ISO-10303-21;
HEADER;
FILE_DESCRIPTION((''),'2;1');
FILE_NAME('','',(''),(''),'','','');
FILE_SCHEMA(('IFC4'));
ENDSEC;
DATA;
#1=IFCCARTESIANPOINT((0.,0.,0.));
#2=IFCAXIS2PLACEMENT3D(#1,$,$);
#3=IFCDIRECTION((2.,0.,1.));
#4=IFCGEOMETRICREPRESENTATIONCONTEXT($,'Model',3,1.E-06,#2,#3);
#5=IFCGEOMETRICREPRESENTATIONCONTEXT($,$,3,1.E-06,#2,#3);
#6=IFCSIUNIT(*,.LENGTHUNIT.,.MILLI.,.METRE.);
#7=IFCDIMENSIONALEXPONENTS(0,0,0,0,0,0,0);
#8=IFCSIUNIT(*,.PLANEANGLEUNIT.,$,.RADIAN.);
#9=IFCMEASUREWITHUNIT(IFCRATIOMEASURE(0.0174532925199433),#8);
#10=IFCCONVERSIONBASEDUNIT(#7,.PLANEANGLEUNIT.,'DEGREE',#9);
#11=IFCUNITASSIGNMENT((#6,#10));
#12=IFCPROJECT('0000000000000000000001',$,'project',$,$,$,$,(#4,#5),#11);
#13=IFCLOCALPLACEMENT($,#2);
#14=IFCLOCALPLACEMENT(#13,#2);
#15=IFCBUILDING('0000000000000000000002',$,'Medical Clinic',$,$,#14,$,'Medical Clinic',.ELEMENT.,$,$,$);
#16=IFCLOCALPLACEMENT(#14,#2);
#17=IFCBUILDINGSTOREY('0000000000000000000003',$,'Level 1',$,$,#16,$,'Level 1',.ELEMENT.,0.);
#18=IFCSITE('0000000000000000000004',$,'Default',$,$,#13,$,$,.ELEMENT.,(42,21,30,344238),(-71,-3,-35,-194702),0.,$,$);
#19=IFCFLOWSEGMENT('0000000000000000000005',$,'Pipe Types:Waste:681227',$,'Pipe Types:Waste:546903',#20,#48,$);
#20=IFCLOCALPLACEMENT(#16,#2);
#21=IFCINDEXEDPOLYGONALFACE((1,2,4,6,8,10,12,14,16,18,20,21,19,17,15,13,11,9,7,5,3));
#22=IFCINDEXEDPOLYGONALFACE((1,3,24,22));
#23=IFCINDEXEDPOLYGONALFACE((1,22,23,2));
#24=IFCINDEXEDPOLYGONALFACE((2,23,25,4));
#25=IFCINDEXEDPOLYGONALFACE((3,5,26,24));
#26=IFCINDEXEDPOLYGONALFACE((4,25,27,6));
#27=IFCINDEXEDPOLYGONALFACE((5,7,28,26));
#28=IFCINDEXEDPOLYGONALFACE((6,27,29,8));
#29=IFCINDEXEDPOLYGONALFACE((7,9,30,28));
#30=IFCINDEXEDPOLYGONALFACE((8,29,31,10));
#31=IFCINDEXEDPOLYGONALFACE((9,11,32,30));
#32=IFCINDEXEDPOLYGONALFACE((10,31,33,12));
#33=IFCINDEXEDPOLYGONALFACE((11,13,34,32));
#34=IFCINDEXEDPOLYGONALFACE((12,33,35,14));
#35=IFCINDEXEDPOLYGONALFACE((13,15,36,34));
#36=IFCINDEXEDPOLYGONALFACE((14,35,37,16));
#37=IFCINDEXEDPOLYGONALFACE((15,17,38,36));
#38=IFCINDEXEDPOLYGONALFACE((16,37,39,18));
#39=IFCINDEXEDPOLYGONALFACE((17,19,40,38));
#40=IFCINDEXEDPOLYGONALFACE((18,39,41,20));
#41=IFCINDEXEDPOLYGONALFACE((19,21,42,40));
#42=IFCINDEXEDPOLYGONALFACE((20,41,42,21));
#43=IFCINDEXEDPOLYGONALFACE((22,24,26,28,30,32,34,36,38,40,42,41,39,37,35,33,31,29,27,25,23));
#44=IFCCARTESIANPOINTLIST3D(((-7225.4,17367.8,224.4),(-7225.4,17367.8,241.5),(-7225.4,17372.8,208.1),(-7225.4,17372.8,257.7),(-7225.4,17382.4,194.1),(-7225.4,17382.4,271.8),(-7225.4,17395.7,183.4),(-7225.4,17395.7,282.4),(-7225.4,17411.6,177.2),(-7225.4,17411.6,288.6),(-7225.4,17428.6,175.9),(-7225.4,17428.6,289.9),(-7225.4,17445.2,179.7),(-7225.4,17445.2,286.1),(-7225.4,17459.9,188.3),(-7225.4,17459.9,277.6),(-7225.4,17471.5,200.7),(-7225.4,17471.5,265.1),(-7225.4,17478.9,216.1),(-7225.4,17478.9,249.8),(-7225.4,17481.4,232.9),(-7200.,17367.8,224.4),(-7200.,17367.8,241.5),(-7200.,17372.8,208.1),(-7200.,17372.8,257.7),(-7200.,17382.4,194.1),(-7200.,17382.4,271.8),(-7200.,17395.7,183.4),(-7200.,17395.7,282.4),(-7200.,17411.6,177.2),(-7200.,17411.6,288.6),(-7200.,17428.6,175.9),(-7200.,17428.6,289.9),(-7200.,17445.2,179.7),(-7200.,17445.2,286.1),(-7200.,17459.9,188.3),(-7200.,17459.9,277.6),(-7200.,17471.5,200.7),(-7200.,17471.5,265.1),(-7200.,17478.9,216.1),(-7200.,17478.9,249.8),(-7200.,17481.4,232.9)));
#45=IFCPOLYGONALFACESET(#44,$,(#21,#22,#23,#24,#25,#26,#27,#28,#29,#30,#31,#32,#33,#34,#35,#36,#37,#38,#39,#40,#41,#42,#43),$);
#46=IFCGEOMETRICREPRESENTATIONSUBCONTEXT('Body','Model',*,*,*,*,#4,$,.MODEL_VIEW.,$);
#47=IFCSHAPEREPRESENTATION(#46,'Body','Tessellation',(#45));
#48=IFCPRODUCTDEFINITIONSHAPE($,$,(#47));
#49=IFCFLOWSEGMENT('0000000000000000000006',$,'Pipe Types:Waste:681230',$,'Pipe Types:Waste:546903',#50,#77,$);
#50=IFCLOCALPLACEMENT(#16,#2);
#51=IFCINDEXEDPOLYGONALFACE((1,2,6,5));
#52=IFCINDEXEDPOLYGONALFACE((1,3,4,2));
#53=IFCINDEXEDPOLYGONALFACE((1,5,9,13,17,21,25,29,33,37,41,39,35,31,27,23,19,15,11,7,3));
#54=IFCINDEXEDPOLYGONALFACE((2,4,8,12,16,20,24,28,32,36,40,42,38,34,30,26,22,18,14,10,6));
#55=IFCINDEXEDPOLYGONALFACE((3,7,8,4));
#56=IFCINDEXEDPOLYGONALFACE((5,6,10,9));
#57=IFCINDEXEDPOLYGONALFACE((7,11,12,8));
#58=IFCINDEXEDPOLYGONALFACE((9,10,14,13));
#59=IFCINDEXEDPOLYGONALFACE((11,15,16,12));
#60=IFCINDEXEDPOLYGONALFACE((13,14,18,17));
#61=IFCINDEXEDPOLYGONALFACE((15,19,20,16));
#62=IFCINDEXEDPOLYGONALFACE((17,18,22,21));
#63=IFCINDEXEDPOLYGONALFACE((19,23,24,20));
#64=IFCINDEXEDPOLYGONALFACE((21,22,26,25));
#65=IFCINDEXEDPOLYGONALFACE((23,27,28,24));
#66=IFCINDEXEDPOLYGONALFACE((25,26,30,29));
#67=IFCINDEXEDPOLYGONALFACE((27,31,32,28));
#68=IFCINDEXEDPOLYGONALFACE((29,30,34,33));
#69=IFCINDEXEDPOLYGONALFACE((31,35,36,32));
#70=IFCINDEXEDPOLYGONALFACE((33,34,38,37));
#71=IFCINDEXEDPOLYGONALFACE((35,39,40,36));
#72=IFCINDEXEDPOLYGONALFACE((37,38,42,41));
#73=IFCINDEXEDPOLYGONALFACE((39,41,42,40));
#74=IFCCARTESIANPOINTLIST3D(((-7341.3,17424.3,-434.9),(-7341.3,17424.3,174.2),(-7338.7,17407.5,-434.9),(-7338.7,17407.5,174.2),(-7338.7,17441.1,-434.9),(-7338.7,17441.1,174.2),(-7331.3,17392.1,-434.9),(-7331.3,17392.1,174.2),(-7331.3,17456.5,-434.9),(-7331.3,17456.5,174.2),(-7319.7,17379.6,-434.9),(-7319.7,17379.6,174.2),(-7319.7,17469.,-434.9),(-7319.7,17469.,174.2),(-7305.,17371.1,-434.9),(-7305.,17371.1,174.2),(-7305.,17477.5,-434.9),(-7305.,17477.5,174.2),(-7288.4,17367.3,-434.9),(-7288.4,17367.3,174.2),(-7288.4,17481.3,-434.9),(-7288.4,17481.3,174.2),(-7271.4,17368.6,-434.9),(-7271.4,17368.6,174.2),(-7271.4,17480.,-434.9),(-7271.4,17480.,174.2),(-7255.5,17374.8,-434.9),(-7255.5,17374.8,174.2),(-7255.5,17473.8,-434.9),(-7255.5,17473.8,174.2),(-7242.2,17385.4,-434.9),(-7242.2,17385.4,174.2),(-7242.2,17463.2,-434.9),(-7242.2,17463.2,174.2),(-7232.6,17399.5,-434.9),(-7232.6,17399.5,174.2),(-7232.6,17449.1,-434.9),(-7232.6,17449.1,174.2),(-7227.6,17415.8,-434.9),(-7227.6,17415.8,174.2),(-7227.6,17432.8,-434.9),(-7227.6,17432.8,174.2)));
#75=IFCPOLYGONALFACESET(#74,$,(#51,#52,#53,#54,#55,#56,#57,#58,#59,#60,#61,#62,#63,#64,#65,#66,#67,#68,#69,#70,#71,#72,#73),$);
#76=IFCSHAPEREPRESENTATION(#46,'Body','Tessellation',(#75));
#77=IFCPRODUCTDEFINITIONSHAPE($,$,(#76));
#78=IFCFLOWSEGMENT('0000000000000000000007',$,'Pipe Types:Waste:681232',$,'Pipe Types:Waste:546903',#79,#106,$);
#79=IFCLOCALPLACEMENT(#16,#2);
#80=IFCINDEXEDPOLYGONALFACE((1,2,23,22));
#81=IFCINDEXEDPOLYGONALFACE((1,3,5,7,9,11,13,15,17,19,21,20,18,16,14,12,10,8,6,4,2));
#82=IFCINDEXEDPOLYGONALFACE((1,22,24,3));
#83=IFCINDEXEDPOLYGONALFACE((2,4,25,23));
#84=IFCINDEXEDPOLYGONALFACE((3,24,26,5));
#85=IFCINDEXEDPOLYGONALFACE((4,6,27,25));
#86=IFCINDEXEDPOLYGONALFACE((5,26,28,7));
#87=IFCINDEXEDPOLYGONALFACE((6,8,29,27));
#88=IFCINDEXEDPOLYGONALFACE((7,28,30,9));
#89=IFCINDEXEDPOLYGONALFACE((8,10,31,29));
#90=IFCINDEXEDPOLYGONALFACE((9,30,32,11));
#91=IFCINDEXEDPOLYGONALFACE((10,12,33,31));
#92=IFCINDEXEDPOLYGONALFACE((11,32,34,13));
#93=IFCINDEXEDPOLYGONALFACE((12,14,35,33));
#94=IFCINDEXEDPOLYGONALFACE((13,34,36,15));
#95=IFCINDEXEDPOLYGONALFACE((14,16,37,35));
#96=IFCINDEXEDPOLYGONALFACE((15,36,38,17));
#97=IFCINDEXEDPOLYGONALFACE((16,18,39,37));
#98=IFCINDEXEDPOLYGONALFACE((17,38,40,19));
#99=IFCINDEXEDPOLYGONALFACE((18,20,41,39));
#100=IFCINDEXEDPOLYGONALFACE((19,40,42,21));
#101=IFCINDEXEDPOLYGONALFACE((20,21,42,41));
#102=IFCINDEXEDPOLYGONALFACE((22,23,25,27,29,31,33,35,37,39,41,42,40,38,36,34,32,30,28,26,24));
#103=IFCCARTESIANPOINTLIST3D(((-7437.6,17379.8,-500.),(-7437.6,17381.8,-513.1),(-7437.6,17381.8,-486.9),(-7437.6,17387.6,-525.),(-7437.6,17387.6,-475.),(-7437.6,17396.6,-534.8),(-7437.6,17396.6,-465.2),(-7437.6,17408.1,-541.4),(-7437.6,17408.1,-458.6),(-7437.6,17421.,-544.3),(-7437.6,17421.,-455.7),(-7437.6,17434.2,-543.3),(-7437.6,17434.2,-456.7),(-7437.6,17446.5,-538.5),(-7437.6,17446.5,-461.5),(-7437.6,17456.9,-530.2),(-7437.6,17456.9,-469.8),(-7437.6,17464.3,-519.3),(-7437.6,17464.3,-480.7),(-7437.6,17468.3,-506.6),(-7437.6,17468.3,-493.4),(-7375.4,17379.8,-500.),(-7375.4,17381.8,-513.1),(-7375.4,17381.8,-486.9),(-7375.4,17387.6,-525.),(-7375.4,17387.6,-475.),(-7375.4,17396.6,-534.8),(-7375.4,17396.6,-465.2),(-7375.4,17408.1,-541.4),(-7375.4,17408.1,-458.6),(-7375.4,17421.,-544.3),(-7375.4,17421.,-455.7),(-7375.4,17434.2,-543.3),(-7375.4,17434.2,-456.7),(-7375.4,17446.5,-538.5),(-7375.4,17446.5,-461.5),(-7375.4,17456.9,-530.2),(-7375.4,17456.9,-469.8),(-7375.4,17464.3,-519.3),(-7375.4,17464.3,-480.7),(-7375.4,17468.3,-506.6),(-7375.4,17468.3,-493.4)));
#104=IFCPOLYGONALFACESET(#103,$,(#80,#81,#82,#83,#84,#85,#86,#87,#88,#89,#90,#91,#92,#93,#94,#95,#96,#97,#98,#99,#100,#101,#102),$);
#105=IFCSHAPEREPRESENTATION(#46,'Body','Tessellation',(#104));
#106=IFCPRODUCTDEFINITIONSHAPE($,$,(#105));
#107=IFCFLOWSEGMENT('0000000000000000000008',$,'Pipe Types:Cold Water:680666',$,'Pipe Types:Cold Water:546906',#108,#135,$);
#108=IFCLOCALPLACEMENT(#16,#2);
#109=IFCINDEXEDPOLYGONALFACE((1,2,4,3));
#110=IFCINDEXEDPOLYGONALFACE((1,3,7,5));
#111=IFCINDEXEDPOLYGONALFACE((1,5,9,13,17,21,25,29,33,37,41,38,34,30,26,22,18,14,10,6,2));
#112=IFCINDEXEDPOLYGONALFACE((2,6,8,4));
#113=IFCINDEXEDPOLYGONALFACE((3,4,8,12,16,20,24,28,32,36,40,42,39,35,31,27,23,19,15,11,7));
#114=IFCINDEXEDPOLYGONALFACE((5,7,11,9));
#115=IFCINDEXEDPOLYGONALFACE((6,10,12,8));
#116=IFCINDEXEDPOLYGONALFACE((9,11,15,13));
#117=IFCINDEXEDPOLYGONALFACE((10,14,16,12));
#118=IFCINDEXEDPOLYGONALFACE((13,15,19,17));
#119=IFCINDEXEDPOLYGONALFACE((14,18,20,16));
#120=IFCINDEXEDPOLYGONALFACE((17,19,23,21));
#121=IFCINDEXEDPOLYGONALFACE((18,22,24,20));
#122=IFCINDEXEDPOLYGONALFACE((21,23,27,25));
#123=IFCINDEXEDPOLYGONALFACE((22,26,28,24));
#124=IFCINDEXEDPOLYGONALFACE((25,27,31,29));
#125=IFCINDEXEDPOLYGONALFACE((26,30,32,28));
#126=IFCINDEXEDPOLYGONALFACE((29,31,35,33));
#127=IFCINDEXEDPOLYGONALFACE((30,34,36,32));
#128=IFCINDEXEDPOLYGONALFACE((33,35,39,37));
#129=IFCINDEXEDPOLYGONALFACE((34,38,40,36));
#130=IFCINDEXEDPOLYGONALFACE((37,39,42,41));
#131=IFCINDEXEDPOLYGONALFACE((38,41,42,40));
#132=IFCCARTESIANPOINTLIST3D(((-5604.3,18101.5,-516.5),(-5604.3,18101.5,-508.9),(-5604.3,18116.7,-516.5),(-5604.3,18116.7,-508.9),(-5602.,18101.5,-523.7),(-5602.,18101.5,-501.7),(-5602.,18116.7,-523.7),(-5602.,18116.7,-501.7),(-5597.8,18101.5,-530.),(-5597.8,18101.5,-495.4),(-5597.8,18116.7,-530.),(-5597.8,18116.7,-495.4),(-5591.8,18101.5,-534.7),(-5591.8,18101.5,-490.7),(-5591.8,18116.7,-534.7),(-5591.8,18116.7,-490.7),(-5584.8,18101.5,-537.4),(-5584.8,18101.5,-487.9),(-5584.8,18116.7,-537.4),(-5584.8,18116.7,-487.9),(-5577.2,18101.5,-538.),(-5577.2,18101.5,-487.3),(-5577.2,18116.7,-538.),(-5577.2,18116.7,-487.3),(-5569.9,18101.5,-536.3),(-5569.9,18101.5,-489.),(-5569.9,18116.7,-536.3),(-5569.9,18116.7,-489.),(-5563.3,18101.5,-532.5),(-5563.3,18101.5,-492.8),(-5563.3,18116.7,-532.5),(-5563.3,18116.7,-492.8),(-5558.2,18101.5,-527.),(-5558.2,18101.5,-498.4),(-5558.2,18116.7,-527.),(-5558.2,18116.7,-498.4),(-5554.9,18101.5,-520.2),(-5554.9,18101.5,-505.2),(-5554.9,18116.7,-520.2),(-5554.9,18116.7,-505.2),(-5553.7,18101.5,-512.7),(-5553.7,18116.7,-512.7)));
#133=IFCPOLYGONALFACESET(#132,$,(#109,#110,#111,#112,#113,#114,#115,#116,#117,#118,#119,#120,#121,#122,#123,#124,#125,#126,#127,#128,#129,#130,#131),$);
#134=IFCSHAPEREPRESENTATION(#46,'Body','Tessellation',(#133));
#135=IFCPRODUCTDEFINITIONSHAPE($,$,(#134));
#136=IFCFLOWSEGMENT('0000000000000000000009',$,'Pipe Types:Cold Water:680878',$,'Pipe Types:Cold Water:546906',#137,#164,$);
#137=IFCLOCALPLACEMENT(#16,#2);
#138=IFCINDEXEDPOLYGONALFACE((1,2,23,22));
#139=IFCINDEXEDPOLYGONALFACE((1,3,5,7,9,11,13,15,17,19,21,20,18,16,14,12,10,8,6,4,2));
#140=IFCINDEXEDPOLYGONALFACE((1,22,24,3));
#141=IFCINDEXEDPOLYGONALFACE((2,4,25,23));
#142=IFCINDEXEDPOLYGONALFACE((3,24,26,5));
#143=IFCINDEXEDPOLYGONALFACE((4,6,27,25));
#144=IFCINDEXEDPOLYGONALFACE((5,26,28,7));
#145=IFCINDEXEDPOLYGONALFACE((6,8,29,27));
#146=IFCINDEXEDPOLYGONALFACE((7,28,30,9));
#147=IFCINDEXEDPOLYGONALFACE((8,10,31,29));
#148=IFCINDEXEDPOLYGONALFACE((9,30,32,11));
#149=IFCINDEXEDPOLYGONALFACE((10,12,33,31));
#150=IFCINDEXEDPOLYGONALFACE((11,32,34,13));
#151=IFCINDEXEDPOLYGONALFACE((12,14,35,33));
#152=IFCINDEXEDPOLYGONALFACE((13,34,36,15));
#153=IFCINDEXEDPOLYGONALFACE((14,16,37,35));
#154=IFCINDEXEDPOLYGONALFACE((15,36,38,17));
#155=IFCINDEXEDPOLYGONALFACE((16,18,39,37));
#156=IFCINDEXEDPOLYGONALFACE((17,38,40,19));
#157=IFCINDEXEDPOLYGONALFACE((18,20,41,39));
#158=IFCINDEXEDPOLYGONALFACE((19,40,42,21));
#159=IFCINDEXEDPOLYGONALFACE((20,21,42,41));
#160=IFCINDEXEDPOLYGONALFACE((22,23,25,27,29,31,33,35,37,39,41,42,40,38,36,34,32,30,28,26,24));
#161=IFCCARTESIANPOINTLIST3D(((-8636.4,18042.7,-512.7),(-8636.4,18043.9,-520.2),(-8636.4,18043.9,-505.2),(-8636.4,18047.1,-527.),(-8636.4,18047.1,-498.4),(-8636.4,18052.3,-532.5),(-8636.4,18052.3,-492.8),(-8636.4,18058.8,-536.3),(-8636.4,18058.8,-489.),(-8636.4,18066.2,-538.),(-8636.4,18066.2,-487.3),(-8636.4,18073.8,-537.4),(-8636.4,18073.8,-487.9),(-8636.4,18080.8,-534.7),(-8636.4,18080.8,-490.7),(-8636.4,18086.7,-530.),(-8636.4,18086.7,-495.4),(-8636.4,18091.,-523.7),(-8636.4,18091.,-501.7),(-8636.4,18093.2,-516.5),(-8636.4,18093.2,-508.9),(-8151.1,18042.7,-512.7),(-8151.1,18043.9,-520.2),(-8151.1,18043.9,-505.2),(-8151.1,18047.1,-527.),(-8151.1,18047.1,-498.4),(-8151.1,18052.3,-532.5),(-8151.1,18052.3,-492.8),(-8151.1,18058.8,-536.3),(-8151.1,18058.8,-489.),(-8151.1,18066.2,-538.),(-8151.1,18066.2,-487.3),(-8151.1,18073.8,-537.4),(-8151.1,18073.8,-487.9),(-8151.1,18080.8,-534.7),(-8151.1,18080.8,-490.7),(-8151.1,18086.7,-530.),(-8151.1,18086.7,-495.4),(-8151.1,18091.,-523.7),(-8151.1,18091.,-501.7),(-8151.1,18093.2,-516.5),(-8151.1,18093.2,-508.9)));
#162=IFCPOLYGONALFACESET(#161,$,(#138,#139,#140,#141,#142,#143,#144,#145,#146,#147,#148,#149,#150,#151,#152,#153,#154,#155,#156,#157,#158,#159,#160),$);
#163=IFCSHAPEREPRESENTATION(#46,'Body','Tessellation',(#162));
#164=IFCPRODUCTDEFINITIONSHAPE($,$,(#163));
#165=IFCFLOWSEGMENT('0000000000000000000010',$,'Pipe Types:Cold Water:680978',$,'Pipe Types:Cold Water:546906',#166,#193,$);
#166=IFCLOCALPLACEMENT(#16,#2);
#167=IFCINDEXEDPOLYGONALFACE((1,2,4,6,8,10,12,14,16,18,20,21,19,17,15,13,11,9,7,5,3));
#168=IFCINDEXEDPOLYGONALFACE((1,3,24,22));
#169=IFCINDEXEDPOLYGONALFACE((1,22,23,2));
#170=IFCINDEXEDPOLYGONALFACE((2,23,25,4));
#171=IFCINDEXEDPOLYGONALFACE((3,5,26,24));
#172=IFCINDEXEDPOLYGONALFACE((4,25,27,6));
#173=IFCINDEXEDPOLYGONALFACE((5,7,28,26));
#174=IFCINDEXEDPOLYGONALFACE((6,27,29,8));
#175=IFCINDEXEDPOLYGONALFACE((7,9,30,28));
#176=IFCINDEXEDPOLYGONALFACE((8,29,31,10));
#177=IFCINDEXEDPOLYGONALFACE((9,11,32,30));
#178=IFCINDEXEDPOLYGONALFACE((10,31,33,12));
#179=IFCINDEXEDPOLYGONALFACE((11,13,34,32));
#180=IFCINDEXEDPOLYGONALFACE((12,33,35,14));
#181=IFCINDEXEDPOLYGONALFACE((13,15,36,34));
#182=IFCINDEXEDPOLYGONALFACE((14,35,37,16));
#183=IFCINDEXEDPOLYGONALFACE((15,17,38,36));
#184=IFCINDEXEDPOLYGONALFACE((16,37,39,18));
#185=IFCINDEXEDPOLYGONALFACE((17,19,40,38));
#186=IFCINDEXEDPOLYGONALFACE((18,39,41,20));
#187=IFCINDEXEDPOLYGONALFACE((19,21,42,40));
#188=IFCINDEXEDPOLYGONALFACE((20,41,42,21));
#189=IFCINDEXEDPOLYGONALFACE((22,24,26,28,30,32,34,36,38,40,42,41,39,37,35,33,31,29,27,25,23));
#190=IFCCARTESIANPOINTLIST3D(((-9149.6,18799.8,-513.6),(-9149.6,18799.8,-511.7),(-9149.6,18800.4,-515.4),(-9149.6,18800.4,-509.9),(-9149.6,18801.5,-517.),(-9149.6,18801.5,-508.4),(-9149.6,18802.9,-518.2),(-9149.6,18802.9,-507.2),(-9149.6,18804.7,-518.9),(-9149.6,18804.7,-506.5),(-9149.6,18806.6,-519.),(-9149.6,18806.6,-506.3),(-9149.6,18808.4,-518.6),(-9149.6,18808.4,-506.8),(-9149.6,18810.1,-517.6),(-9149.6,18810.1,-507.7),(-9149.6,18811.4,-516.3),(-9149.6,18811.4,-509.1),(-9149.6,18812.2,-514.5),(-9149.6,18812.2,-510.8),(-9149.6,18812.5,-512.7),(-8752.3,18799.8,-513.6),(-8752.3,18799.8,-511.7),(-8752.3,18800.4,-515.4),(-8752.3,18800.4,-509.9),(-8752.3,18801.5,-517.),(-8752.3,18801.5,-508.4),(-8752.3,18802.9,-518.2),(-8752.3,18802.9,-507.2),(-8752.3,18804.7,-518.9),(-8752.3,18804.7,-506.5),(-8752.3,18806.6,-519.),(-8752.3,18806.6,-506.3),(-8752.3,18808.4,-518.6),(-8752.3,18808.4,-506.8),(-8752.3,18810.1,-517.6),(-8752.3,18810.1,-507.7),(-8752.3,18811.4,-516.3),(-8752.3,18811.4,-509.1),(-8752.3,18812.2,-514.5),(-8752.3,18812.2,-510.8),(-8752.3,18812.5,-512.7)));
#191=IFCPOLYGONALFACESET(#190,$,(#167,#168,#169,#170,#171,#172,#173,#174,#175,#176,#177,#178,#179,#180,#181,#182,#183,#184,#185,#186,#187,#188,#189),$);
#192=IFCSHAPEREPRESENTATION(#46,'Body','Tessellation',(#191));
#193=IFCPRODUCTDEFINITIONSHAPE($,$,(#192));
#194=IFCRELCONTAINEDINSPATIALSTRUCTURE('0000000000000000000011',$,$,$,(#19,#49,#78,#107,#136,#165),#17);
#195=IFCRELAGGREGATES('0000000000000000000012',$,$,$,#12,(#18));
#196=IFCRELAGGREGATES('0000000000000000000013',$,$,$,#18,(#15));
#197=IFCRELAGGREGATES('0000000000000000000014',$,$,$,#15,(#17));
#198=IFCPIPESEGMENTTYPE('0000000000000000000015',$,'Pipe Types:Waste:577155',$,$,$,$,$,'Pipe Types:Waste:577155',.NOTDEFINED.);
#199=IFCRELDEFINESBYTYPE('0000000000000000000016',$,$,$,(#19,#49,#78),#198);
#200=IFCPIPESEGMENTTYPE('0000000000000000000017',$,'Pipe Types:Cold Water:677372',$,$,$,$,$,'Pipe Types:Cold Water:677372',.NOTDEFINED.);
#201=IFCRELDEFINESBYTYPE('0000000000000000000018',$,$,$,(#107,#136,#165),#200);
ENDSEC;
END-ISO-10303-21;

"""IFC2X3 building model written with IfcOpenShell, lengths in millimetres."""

from ifc_helpers import new_model, entity, si_unit, converted_unit, direction, frame, frame_2d, origin, origin_2d_with_axis, place, context, subcontext, project, spatial, circle, extrude, type_object, element, save


model = new_model("IFC2X3")

# Units and contexts
model_context = context("Model", 3, precision=1e-06, world=origin(), true_north=direction((2.0, 0.0, 1.0)))
context_of_model = context(None, 3, precision=1e-06, world=origin(), true_north=direction((2.0, 0.0, 1.0)))
body_context = subcontext(model_context, "Body", "Model", "MODEL_VIEW")
ifc_project = project(units=[si_unit("LENGTHUNIT", "METRE", prefix="MILLI"), converted_unit("PLANEANGLEUNIT", "DEGREE", entity("IfcRatioMeasure", 0.0174532925199433), si_unit("PLANEANGLEUNIT", "RADIAN"), dimensions=[0, 0, 0, 0, 0, 0, 0])], contexts=[model_context, context_of_model])

# Site, building, storey
site_placement = place(None, origin())
site = spatial("IfcSite", under=ifc_project, at=site_placement, Name="Default", CompositionType="ELEMENT", RefLatitude=(42, 21, 30, 344238), RefLongitude=(-71, -3, -35, -194702), RefElevation=0.0)
building_placement = place(site_placement, origin())
building = spatial("IfcBuilding", under=site, at=building_placement, Name="Medical Clinic", LongName="Medical Clinic", CompositionType="ELEMENT")
storey_placement = place(building_placement, origin())
storey = spatial("IfcBuildingStorey", under=building, at=storey_placement, Name="Level 1", LongName="Level 1", CompositionType="ELEMENT", Elevation=0.0)

# Flow segments
pipe_segment_type_1 = type_object("IfcPipeSegmentType", Name="Pipe Types:Waste:577155", ElementType="Pipe Types:Waste:577155", PredefinedType="NOTDEFINED")
flow_segment_1_placement = place(storey_placement, origin())
element("IfcFlowSegment", 1, at=flow_segment_1_placement, inside=storey, type_object=pipe_segment_type_1, Name="Pipe Types:Waste:681227", ObjectType="Pipe Types:Waste:546903", context=body_context, shape_type="SweptSolid", body=[
    extrude(circle(Radius=57.1, at=frame_2d((0.0, 0.0), x_axis=(1.0, 0.0))), frame((-7225.4, 17424.3, 232.9), z_axis=(1.0, 0.0, 0.0), x_axis=(0.0, 1.0, 0.0)), (0.0, 0.0, 1.0), 25.4),
])
flow_segment_2_placement = place(storey_placement, origin())
element("IfcFlowSegment", 2, at=flow_segment_2_placement, inside=storey, type_object=pipe_segment_type_1, Name="Pipe Types:Waste:681230", ObjectType="Pipe Types:Waste:546903", context=body_context, shape_type="SweptSolid", body=[
    extrude(circle(Radius=57.1, at=origin_2d_with_axis()), frame((-7284.1, 17424.3, -434.9), z_axis=(0.0, 0.0, 1.0), x_axis=(-1.0, 0.0, 0.0)), (0.0, 0.0, 1.0), 609.1),
])
flow_segment_3_placement = place(storey_placement, origin())
element("IfcFlowSegment", 3, at=flow_segment_3_placement, inside=storey, type_object=pipe_segment_type_1, Name="Pipe Types:Waste:681232", ObjectType="Pipe Types:Waste:546903", context=body_context, shape_type="SweptSolid", body=[
    extrude(circle(Radius=44.5, at=frame_2d((0.0, 0.0), x_axis=(1.0, 0.0))), frame((-7437.6, 17424.3, -500.0), z_axis=(1.0, 0.0, 0.0), x_axis=(0.0, -1.0, 0.0)), (0.0, 0.0, 1.0), 62.2),
])
pipe_segment_type_2 = type_object("IfcPipeSegmentType", Name="Pipe Types:Cold Water:677372", ElementType="Pipe Types:Cold Water:677372", PredefinedType="NOTDEFINED")
flow_segment_4_placement = place(storey_placement, origin())
element("IfcFlowSegment", 4, at=flow_segment_4_placement, inside=storey, type_object=pipe_segment_type_2, Name="Pipe Types:Cold Water:680666", ObjectType="Pipe Types:Cold Water:546906", context=body_context, shape_type="SweptSolid", body=[
    extrude(circle(Radius=25.4, at=origin_2d_with_axis()), frame((-5579.1, 18101.5, -512.7), z_axis=(0.0, 1.0, 0.0), x_axis=(1.0, 0.0, 0.0)), (0.0, 0.0, 1.0), 15.2),
])
flow_segment_5_placement = place(storey_placement, origin())
element("IfcFlowSegment", 5, at=flow_segment_5_placement, inside=storey, type_object=pipe_segment_type_2, Name="Pipe Types:Cold Water:680878", ObjectType="Pipe Types:Cold Water:546906", context=body_context, shape_type="SweptSolid", body=[
    extrude(circle(Radius=25.4, at=frame_2d((0.0, 0.0), x_axis=(1.0, 0.0))), frame((-8636.4, 18068.1, -512.7), z_axis=(1.0, 0.0, 0.0), x_axis=(0.0, -1.0, 0.0)), (0.0, 0.0, 1.0), 485.4),
])
flow_segment_6_placement = place(storey_placement, origin())
element("IfcFlowSegment", 6, at=flow_segment_6_placement, inside=storey, type_object=pipe_segment_type_2, Name="Pipe Types:Cold Water:680978", ObjectType="Pipe Types:Cold Water:546906", context=body_context, shape_type="SweptSolid", body=[
    extrude(circle(Radius=6.3, at=origin_2d_with_axis()), frame((-9149.6, 18806.1, -512.7), z_axis=(1.0, 0.0, 0.0), x_axis=(0.0, 1.0, 0.0)), (0.0, 0.0, 1.0), 397.3),
])

save(model, "model.ifc")
